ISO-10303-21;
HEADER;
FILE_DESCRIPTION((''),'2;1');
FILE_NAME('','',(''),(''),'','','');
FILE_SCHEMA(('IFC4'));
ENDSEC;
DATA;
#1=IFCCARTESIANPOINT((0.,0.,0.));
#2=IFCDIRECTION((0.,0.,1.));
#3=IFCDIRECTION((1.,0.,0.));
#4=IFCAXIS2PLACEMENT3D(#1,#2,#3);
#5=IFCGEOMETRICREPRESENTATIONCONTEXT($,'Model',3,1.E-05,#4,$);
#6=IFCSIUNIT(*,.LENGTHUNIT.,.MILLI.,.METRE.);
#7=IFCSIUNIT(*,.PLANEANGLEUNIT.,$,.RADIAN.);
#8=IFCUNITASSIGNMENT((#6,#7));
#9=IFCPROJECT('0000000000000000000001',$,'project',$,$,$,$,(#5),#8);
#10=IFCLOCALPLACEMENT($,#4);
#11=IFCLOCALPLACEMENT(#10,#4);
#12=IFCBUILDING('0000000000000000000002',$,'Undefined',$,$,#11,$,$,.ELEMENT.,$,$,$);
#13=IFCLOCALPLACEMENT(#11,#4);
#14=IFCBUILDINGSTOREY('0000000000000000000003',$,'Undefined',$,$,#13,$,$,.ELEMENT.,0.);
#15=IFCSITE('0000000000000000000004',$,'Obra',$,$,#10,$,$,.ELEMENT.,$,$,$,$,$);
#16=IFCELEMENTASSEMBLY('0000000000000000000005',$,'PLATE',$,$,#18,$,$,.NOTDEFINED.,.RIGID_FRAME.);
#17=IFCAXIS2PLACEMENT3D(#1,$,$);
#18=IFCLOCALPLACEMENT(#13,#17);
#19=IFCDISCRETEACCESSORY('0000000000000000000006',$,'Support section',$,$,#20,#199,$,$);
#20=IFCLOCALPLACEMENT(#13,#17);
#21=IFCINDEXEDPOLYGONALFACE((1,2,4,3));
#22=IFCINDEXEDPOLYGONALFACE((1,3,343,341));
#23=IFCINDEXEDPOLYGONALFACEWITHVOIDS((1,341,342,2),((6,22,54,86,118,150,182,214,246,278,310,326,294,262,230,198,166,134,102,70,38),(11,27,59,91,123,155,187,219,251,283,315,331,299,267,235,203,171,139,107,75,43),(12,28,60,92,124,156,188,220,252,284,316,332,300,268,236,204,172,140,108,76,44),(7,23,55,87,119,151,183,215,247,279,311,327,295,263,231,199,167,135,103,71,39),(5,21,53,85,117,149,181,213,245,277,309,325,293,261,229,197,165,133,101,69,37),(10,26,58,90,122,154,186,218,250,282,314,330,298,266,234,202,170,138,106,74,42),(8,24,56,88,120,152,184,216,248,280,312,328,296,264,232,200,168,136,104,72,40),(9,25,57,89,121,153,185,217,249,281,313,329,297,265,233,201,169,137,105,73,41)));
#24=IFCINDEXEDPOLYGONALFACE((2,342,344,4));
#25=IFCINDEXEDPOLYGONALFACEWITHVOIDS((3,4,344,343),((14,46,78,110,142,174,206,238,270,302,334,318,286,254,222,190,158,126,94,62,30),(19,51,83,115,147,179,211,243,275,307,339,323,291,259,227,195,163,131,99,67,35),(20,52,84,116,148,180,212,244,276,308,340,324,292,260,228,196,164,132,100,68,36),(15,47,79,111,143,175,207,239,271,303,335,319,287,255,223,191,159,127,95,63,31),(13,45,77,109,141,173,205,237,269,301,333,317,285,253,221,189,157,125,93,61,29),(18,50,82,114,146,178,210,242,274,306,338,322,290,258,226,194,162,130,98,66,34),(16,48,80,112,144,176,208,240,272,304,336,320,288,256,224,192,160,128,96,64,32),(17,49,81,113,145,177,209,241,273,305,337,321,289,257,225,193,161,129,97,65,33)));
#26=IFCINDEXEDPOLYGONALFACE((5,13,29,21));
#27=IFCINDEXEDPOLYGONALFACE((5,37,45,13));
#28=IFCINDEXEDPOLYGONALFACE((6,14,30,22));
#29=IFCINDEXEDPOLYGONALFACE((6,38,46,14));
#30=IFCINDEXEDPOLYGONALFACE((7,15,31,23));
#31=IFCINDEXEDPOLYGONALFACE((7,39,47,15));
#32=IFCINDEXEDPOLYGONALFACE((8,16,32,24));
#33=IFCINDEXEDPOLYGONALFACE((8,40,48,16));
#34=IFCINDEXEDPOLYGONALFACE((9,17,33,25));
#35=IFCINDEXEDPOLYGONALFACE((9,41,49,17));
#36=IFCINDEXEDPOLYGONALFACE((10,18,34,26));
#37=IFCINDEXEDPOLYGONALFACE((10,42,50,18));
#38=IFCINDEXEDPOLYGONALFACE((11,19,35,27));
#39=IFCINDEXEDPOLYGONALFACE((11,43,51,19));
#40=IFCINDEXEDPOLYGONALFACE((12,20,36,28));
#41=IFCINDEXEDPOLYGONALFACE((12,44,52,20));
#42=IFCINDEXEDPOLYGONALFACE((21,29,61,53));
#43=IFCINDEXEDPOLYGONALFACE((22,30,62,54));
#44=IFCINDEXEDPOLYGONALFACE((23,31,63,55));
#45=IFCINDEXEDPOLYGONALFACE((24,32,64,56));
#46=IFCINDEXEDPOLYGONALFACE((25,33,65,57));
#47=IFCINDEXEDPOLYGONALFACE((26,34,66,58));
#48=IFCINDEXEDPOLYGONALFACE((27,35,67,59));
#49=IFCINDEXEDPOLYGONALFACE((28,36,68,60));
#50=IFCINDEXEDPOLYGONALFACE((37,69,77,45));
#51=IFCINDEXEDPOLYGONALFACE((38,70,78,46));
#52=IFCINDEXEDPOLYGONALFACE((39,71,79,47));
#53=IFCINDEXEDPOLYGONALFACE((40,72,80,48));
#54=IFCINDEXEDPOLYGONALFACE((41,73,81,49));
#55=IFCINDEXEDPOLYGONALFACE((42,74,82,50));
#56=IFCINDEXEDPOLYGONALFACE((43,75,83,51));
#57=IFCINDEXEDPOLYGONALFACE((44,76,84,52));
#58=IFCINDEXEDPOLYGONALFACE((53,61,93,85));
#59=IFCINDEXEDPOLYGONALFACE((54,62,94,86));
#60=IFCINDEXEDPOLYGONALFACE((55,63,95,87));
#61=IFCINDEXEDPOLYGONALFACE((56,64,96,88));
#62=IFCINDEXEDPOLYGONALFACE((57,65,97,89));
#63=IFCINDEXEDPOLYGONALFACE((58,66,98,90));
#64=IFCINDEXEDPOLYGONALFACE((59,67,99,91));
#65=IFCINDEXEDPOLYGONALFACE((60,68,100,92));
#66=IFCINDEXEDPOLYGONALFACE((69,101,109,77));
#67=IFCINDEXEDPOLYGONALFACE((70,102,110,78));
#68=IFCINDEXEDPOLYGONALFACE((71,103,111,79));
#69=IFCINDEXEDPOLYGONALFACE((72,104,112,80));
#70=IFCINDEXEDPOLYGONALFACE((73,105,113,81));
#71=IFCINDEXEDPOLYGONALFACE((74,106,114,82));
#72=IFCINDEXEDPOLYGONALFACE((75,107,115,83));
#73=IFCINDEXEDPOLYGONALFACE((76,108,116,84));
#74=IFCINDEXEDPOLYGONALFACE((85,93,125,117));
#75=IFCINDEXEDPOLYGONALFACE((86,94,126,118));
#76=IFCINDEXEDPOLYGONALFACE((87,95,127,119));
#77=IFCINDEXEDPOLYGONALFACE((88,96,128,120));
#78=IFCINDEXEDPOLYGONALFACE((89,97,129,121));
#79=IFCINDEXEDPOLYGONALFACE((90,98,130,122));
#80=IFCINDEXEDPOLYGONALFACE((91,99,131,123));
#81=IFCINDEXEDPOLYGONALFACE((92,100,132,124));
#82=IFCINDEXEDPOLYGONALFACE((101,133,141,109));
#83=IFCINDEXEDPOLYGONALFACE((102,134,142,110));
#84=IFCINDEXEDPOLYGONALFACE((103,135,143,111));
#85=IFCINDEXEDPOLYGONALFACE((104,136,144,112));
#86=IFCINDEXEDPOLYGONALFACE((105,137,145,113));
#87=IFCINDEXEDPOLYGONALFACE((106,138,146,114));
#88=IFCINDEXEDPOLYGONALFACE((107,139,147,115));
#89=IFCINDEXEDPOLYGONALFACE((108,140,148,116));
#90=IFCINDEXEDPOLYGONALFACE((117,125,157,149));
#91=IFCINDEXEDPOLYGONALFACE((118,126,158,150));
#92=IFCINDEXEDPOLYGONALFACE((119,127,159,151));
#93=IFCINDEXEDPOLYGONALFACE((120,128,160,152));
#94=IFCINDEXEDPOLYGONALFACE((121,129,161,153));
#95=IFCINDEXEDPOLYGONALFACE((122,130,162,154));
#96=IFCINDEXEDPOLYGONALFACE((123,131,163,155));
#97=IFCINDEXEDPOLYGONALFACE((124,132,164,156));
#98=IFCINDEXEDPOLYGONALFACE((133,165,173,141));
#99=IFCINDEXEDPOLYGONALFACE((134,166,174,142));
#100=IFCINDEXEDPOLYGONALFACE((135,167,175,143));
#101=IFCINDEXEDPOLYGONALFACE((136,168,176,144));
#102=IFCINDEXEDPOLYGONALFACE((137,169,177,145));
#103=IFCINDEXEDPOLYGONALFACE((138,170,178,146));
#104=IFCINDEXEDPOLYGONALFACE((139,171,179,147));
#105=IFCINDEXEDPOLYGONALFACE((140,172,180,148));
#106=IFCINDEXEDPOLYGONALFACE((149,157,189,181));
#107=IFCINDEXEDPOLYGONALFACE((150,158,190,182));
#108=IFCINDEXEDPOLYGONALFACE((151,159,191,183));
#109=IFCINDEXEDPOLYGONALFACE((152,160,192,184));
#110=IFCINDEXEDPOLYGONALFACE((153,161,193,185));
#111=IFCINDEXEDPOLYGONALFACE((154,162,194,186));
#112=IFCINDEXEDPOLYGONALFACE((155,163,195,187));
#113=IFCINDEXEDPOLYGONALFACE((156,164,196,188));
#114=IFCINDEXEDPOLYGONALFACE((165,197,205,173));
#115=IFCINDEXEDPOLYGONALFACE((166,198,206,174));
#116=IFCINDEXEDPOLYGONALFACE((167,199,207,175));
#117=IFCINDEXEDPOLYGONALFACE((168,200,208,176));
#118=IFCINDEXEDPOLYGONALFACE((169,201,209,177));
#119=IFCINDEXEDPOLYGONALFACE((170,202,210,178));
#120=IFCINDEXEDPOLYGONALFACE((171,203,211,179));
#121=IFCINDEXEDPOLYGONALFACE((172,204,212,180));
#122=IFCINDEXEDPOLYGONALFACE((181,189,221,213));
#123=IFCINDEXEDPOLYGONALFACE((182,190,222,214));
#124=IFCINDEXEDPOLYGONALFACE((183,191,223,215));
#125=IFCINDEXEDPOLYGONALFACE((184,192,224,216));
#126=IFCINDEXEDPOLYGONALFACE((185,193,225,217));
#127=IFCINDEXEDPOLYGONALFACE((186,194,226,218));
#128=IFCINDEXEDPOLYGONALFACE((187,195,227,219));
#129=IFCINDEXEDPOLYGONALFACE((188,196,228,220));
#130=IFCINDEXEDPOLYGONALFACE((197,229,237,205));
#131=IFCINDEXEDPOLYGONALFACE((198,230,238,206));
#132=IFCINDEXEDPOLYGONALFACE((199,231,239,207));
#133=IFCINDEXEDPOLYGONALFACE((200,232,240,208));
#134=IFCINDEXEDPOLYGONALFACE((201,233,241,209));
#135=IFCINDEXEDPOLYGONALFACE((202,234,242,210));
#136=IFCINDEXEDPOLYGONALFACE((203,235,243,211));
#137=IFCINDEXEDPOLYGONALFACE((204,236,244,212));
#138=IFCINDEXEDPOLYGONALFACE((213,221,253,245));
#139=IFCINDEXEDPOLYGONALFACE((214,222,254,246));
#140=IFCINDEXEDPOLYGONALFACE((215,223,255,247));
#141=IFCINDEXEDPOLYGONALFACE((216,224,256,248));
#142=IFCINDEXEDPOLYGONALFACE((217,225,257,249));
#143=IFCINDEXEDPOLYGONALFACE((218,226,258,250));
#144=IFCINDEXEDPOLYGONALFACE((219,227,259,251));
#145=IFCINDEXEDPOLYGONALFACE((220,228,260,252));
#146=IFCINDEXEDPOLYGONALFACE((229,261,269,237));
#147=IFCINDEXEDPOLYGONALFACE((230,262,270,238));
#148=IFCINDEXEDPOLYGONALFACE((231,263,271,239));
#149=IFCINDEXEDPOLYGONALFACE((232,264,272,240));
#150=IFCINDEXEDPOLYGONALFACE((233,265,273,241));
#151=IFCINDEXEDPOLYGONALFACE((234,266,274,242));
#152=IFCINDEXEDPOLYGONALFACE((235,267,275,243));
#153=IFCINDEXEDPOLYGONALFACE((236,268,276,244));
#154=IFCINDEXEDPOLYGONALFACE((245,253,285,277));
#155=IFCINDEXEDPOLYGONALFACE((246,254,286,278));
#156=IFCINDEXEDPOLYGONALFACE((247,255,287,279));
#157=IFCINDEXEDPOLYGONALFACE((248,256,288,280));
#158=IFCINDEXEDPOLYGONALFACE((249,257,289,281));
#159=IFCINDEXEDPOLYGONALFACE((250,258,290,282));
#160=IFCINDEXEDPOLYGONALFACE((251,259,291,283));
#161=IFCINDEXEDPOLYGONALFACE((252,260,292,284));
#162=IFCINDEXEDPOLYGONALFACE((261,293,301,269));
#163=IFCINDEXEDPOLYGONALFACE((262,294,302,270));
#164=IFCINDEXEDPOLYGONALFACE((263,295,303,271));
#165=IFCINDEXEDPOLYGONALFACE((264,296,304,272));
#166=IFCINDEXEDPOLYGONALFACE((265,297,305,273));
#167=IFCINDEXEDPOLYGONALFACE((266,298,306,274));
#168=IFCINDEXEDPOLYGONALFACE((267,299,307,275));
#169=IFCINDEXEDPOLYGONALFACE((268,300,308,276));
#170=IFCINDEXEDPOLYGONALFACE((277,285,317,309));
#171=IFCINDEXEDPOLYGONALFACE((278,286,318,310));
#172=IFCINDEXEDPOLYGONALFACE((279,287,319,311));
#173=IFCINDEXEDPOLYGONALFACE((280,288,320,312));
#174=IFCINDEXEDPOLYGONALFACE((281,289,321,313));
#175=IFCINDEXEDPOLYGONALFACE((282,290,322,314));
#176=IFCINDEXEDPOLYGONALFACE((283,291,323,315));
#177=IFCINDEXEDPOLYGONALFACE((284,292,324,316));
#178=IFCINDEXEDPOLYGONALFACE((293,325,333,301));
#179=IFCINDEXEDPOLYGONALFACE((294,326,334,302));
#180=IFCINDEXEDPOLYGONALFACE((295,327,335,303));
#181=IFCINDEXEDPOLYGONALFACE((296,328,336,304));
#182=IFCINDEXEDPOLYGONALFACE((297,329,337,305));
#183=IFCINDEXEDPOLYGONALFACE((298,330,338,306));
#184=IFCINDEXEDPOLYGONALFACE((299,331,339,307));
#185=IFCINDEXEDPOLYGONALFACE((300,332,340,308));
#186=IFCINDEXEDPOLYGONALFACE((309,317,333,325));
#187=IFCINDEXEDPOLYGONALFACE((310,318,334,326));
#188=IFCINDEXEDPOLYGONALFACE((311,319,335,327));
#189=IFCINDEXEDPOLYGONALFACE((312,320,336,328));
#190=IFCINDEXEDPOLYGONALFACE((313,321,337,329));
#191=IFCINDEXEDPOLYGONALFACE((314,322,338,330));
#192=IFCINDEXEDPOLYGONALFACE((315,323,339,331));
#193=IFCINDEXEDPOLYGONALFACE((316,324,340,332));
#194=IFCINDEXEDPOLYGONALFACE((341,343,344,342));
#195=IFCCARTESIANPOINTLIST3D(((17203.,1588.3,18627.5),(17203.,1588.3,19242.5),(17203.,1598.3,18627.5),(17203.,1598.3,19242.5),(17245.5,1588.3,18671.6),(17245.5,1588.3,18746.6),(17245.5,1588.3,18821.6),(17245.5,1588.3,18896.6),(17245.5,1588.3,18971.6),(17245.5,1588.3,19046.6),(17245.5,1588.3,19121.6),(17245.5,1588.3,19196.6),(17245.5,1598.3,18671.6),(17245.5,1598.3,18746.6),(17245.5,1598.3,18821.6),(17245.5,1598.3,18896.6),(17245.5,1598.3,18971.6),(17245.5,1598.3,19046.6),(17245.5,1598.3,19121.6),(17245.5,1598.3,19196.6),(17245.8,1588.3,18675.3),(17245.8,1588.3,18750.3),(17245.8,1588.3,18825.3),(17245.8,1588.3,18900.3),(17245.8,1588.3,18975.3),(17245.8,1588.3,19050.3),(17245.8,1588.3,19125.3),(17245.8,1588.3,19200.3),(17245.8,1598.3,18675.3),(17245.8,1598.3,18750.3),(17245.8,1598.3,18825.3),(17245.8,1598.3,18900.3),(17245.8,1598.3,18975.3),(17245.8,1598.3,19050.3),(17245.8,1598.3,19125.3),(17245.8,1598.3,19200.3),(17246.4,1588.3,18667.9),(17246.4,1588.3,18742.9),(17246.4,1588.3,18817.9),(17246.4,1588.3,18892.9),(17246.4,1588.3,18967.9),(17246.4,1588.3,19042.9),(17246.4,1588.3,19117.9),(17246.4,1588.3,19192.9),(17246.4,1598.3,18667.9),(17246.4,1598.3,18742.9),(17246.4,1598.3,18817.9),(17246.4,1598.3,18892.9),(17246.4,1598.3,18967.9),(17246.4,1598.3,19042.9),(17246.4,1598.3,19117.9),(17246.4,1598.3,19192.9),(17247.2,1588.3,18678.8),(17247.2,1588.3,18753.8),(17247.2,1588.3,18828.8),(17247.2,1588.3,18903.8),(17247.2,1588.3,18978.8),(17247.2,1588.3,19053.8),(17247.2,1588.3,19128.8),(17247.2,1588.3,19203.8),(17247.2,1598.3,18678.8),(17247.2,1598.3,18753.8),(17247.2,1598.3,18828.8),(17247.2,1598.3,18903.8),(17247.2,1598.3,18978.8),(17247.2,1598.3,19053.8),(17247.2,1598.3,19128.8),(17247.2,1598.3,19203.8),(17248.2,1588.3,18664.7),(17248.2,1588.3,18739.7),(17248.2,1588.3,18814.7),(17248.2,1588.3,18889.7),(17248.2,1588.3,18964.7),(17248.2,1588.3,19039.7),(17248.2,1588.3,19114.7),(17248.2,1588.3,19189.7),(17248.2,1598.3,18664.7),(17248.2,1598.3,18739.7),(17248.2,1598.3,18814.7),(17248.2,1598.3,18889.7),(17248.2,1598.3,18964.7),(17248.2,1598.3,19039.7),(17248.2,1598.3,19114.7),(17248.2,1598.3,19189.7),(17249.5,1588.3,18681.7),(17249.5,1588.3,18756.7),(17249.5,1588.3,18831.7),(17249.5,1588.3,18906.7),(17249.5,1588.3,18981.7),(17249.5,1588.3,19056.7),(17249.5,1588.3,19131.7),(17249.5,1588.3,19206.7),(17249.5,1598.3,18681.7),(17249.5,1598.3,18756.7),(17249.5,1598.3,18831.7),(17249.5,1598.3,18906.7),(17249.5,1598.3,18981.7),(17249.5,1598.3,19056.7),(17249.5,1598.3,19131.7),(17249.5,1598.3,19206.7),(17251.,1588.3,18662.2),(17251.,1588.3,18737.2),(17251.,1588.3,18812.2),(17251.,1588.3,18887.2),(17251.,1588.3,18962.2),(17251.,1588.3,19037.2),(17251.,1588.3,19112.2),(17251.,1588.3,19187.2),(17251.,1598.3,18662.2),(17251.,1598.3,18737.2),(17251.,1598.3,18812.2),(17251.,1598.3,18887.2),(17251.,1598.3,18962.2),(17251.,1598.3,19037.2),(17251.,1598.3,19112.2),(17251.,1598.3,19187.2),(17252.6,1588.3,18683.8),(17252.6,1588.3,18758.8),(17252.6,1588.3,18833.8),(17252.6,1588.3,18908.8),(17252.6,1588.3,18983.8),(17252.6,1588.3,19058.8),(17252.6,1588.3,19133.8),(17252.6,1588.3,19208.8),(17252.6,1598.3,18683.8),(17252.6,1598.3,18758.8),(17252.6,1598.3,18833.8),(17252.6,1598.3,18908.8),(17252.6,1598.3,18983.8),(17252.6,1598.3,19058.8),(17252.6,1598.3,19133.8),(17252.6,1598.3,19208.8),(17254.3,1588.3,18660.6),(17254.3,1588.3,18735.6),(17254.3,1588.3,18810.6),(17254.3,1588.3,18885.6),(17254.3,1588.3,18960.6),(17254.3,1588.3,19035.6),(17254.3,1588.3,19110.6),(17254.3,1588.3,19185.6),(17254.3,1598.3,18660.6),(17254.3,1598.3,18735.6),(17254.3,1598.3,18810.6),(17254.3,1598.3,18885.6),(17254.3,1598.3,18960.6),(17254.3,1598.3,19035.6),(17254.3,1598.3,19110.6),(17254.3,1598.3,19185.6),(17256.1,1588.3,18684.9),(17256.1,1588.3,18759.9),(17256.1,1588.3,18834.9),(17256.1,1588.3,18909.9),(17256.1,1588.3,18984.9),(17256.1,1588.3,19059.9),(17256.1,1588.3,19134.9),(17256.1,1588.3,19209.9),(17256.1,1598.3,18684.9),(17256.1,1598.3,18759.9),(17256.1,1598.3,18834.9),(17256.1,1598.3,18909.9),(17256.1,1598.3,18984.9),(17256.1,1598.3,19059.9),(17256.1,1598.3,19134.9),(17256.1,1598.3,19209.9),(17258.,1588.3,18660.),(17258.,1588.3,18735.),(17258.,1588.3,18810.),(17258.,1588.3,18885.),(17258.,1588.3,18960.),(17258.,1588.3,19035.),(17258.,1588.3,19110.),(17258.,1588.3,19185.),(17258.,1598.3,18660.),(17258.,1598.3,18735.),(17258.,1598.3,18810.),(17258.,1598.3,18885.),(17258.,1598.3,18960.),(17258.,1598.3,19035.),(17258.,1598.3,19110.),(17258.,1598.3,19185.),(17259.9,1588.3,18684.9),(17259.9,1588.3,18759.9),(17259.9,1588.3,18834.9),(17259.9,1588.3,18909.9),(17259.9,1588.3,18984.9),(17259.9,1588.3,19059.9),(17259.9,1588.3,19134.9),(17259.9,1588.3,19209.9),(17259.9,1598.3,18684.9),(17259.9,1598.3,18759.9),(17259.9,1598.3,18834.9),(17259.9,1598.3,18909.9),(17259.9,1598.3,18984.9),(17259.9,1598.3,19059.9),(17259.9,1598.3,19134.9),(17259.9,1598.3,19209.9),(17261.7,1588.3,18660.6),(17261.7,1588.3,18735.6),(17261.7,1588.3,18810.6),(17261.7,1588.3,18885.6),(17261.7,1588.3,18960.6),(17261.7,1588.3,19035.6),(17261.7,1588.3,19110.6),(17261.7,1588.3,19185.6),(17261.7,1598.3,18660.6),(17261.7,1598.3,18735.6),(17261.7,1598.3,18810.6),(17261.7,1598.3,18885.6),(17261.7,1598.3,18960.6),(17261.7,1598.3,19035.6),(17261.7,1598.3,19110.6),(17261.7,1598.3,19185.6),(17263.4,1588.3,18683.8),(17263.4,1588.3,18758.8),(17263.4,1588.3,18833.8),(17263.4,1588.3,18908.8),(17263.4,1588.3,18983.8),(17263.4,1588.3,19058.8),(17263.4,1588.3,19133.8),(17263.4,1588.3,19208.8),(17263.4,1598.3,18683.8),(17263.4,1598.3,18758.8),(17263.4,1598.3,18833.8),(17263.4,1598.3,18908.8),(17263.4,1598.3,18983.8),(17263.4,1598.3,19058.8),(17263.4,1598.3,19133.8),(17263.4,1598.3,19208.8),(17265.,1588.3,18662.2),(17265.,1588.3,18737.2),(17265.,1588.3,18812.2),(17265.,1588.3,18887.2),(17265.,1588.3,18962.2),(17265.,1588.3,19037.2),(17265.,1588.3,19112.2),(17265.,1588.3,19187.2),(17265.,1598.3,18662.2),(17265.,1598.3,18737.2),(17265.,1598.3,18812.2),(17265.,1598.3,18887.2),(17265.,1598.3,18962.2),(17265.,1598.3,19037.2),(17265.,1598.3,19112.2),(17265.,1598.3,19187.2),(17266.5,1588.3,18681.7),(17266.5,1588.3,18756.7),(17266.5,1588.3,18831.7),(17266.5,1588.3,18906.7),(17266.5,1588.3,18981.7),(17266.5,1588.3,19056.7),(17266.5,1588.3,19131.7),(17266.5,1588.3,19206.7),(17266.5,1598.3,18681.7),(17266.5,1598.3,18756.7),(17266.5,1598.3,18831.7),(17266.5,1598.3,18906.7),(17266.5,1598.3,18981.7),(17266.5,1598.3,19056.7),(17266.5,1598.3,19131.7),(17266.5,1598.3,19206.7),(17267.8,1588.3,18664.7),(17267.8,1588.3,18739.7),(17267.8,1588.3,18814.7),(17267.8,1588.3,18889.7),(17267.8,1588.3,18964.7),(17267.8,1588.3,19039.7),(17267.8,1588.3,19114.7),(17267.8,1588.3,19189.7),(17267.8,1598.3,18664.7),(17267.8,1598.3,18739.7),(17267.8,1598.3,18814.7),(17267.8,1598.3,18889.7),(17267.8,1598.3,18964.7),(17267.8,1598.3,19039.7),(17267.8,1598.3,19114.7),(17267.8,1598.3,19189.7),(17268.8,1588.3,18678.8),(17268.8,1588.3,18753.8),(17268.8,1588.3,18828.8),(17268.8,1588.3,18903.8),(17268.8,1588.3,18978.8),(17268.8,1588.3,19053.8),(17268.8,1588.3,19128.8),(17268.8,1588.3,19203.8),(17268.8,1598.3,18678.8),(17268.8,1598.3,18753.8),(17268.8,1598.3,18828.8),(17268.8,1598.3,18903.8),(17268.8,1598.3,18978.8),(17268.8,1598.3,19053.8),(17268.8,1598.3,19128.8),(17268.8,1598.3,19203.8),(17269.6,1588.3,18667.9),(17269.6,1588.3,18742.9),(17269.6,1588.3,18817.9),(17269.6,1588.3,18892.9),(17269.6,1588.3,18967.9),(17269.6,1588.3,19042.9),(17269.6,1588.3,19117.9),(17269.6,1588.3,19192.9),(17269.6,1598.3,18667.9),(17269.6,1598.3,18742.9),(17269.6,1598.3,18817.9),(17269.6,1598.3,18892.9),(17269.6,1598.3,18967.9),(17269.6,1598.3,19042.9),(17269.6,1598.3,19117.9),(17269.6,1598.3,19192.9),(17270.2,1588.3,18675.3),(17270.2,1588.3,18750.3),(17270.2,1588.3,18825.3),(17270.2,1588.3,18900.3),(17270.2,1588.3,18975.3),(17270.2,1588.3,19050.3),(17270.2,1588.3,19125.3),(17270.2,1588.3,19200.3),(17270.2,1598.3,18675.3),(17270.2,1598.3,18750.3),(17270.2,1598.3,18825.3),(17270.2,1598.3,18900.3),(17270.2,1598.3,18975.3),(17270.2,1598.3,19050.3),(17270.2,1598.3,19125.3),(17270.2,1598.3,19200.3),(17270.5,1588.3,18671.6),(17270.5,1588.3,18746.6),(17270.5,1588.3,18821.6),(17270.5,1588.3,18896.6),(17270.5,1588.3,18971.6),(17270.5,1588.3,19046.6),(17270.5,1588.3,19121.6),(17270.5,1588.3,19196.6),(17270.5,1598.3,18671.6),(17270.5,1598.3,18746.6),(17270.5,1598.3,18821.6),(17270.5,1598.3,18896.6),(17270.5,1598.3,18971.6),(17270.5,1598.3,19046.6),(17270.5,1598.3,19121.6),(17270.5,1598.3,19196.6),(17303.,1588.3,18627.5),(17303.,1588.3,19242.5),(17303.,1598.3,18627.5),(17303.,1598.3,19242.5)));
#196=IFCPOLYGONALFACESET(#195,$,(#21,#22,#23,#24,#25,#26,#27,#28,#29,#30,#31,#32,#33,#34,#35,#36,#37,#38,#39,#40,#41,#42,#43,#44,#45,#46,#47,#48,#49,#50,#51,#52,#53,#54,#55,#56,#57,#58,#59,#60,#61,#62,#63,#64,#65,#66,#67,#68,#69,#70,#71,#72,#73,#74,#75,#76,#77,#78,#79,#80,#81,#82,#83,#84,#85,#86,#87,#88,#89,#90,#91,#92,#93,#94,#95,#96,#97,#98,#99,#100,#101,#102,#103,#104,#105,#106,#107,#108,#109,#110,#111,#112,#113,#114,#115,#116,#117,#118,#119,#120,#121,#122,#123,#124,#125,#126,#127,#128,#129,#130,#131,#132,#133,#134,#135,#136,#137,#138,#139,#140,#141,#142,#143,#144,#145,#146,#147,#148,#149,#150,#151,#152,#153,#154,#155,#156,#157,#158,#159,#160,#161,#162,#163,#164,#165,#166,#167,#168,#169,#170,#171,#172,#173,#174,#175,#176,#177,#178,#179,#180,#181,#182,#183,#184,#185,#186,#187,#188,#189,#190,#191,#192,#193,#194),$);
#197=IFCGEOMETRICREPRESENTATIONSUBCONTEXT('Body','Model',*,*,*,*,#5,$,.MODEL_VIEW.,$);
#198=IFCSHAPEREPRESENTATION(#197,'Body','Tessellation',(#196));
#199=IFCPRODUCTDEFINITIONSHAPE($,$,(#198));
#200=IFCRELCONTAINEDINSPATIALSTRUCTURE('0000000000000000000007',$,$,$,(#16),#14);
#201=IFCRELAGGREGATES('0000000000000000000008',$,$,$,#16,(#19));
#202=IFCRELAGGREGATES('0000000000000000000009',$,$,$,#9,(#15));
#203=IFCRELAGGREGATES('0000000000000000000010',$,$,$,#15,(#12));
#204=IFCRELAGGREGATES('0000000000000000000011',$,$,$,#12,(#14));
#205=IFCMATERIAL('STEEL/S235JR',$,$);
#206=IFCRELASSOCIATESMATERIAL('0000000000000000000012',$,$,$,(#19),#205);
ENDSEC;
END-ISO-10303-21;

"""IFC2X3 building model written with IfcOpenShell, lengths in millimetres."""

from ifc_helpers import new_model, si_unit, frame, origin_with_axes, origin_2d_with_axis, place, context, subcontext, project, spatial, rectangle, circle, extrude, source, transform, mapped, material, element, aggregate, save


model = new_model("IFC2X3")

# Units and contexts
model_context = context("Model", 3, precision=1e-05, world=origin_with_axes())
body_context = subcontext(model_context, "Body", "Model", "MODEL_VIEW")
ifc_project = project(units=[si_unit("LENGTHUNIT", "METRE", prefix="MILLI"), si_unit("PLANEANGLEUNIT", "RADIAN")], contexts=[model_context])

# Site, building, storey
site_placement = place(None, origin_with_axes())
site = spatial("IfcSite", under=ifc_project, at=site_placement, Name="Obra", CompositionType="ELEMENT")
building_placement = place(site_placement, origin_with_axes())
building = spatial("IfcBuilding", under=site, at=building_placement, Name="Undefined", CompositionType="ELEMENT")
storey_placement = place(building_placement, origin_with_axes())
storey = spatial("IfcBuildingStorey", under=building, at=storey_placement, Name="Undefined", CompositionType="ELEMENT", Elevation=0.0)

# Shared definitions
ifc_material_1 = material(Name="STEEL/S235JR")

# Element assembly, discrete accessory, opening
assembly_1_placement = place(storey_placement, origin_with_axes())
assembly_1 = element("IfcElementAssembly", 1, at=assembly_1_placement, inside=storey, Name="PLATE", AssemblyPlace="NOTDEFINED", PredefinedType="RIGID_FRAME")
discrete_accessory_1_placement = place(assembly_1_placement, frame((17253.0, 1593.3, 18627.5), z_axis=(0.0, 0.0, 1.0), x_axis=(-1.0, 0.0, 0.0)))
discrete_accessory_1 = element("IfcDiscreteAccessory", 2, at=discrete_accessory_1_placement, material=ifc_material_1, Name="Support section", context=body_context, shape_type="SweptSolid", body=[
    extrude(rectangle(XDim=10.0, YDim=100.0, at=origin_2d_with_axis()), frame((0.0, 0.0, 615.0), z_axis=(0.0, 0.0, -1.0), x_axis=(0.0, 1.0, 0.0)), (0.0, 0.0, 1.0), 615.0),
])
shared_shape_1 = source(origin_with_axes(), body_context, "Body", "SweptSolid", [
    extrude(circle(Radius=12.5, at=origin_2d_with_axis()), frame((0.0, -15.1, 0.0), z_axis=(0.0, 1.0, 0.0), x_axis=(1.0, 0.0, 0.0)), (0.0, 0.0, 1.0), 10.2),
])
opening_1_placement = place(assembly_1_placement, frame((17213.0, 1603.3, 19350.0), z_axis=(1.0, 0.0, 0.0), x_axis=(0.0, 0.0, -1.0)))
element("IfcOpeningElement", 3, at=opening_1_placement, cuts=discrete_accessory_1, ObjectType="Opening", context=body_context, shape_type="MappedRepresentation", body=[
    mapped(shared_shape_1, transform((152.5, 0.0, 45.0))),
    mapped(shared_shape_1, transform((227.5, 0.0, 45.0))),
    mapped(shared_shape_1, transform((302.5, 0.0, 45.0))),
    mapped(shared_shape_1, transform((377.5, 0.0, 45.0))),
    mapped(shared_shape_1, transform((452.5, 0.0, 45.0))),
    mapped(shared_shape_1, transform((527.5, 0.0, 45.0))),
    mapped(shared_shape_1, transform((602.5, 0.0, 45.0))),
    mapped(shared_shape_1, transform((677.5, 0.0, 45.0))),
])
aggregate(assembly_1, [discrete_accessory_1])

save(model, "model.ifc")
